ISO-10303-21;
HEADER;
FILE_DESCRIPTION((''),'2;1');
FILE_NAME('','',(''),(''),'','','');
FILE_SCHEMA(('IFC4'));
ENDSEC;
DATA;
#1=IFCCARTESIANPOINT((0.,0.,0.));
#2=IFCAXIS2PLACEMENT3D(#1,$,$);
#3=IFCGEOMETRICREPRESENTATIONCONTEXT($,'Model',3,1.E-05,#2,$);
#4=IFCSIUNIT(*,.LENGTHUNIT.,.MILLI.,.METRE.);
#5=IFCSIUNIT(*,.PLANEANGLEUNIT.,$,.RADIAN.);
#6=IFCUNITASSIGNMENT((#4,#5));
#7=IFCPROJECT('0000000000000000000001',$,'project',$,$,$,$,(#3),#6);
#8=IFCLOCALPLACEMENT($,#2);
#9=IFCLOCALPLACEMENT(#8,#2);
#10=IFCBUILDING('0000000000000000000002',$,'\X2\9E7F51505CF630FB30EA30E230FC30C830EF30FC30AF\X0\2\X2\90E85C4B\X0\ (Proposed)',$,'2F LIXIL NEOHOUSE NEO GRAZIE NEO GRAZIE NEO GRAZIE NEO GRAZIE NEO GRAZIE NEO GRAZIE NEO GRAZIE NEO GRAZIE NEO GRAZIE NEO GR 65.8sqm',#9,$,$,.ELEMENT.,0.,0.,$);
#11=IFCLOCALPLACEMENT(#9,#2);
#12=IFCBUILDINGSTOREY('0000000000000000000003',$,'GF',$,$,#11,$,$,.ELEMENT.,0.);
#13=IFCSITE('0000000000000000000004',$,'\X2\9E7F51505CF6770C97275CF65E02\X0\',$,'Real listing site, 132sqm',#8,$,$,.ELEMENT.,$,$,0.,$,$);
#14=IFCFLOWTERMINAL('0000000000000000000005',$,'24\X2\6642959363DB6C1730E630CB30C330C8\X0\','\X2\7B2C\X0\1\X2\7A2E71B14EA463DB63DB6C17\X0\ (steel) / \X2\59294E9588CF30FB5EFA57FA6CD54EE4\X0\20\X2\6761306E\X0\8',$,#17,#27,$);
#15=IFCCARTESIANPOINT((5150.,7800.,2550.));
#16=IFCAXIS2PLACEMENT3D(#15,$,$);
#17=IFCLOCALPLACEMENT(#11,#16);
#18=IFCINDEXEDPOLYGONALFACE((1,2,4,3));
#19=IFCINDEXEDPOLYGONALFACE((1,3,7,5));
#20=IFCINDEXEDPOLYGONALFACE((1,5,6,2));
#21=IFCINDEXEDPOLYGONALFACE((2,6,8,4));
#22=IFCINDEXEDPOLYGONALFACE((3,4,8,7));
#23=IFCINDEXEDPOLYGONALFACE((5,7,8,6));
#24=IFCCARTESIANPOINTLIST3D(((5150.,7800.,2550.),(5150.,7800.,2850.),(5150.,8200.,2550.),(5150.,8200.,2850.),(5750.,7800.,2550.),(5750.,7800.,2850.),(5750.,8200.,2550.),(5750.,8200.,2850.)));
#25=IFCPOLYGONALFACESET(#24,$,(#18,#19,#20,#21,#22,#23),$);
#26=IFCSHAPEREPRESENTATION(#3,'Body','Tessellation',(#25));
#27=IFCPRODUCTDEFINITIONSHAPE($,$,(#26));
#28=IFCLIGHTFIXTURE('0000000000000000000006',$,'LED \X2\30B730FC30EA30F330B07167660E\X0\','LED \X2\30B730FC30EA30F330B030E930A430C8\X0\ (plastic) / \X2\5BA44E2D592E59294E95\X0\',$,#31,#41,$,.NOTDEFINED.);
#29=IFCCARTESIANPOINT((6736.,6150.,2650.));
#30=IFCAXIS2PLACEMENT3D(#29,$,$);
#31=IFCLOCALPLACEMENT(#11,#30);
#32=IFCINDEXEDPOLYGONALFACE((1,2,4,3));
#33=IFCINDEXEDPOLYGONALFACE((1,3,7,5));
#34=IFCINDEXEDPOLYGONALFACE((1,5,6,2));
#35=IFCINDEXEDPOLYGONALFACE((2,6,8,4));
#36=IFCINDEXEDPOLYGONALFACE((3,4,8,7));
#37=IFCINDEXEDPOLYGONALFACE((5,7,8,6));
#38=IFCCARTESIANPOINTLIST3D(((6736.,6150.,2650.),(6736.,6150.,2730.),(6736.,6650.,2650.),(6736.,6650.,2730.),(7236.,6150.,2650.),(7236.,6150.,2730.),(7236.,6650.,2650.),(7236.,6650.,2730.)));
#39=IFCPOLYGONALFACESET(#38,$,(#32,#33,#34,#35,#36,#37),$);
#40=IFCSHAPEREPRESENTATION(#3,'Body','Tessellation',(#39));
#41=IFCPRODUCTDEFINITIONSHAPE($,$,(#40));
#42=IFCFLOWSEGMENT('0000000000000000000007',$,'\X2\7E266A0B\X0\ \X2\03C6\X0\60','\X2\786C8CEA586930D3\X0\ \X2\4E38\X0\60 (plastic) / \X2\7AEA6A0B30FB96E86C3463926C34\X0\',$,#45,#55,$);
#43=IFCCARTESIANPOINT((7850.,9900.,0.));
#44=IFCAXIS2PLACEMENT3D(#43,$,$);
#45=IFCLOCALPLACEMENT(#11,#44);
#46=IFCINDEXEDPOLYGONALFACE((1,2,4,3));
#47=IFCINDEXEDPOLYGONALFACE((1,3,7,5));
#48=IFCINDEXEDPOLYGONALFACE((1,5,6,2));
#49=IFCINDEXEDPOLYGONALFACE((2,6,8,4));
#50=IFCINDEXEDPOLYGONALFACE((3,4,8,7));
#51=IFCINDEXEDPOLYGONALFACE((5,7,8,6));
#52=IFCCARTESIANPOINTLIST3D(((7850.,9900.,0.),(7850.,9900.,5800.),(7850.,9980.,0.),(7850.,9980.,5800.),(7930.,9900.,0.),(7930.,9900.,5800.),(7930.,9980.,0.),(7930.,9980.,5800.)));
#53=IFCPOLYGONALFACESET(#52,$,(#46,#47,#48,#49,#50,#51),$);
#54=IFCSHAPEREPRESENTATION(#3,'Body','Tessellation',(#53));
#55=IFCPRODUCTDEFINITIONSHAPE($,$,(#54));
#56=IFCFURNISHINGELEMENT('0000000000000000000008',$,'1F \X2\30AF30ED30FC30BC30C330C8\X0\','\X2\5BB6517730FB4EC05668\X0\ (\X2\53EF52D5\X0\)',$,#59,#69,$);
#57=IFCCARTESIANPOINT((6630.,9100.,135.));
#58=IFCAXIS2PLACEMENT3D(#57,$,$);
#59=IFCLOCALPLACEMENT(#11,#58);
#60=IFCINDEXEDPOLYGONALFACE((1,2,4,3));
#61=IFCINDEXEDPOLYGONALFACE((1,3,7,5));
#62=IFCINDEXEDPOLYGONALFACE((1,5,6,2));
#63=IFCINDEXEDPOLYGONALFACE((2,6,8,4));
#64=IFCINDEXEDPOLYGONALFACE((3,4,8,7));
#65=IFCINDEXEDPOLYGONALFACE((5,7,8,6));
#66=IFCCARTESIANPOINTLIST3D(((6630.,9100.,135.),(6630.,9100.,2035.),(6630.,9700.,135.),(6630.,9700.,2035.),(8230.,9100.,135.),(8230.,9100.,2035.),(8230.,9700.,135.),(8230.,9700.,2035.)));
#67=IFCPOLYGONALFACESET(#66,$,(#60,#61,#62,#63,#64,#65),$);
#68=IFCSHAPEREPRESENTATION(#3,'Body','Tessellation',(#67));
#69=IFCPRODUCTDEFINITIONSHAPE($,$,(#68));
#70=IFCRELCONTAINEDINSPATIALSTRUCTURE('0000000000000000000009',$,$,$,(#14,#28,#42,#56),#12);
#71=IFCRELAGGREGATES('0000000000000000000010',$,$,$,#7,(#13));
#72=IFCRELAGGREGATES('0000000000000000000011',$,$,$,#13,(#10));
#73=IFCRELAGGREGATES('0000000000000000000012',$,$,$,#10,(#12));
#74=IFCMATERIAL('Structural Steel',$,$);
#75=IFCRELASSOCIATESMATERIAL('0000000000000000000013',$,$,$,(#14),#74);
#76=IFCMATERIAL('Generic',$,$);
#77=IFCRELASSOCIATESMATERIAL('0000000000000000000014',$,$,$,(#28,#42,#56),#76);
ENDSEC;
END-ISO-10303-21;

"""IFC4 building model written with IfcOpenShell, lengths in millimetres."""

from ifc_helpers import new_model, si_unit, frame, frame_2d, origin, place, context, project, spatial, rectangle, extrude, material, element, save


model = new_model("IFC4")

# Units and contexts
model_context = context("Model", 3, precision=1e-05, world=origin())
ifc_project = project(units=[si_unit("LENGTHUNIT", "METRE", prefix="MILLI"), si_unit("PLANEANGLEUNIT", "RADIAN")], contexts=[model_context])

# Site, building, storey
site_placement = place(None, origin())
site = spatial("IfcSite", under=ifc_project, at=site_placement, Name="鹿児島県霧島市", ObjectType="Real listing site, 132sqm", CompositionType="ELEMENT", RefElevation=0.0)
building_placement = place(site_placement, origin())
building = spatial("IfcBuilding", under=site, at=building_placement, Name="鹿児島・リモートワーク2部屋 (Proposed)", ObjectType="2F LIXIL NEOHOUSE NEO GRAZIE NEO GRAZIE NEO GRAZIE NEO GRAZIE NEO GRAZIE NEO GRAZIE NEO GRAZIE NEO GRAZIE NEO GRAZIE NEO GR 65.8sqm", CompositionType="ELEMENT", ElevationOfRefHeight=0.0, ElevationOfTerrain=0.0)
storey_placement = place(building_placement, origin())
storey = spatial("IfcBuildingStorey", under=building, at=storey_placement, Name="GF", CompositionType="ELEMENT", Elevation=0.0)

# Shared definitions
ifc_material_1 = material(Name="Generic")

# Flow terminal
ifc_material_2 = material(Name="Structural Steel")
flow_terminal_placement = place(storey_placement, frame((5150.0, 7800.0, 2550.0)))
element("IfcFlowTerminal", 1, at=flow_terminal_placement, inside=storey, material=ifc_material_2, Name="24時間換気ユニット", Description="第1種熱交換換気 (steel) / 天井裏・建基法令20条の8", context=model_context, shape_type="SweptSolid", body=[
    extrude(rectangle(XDim=600.0, YDim=400.0, at=frame_2d((300.0, 200.0))), frame((5150.0, 7800.0, 2550.0)), (0.0, 0.0, 1.0), 300.0),
])

# Light fixture
light_fixture_placement = place(storey_placement, frame((6736.0, 6150.0, 2650.0)))
element("IfcLightFixture", 2, at=light_fixture_placement, inside=storey, material=ifc_material_1, Name="LED シーリング照明", Description="LED シーリングライト (plastic) / 室中央天井", PredefinedType="NOTDEFINED", context=model_context, shape_type="SweptSolid", body=[
    extrude(rectangle(XDim=500.0, YDim=500.0, at=frame_2d((250.0, 250.0))), frame((6736.0, 6150.0, 2650.0)), (0.0, 0.0, 1.0), 80.0),
])

# Flow segment
flow_segment_placement = place(storey_placement, frame((7850.0, 9900.0, 0.0)))
element("IfcFlowSegment", 3, at=flow_segment_placement, inside=storey, material=ifc_material_1, Name="縦樋 φ60", Description="硬質塩ビ 丸60 (plastic) / 竪樋・雨水排水", context=model_context, shape_type="SweptSolid", body=[
    extrude(rectangle(XDim=80.0, YDim=80.0, at=frame_2d((40.0, 40.0))), frame((7850.0, 9900.0, 0.0)), (0.0, 0.0, 1.0), 5800.0),
])

# Furnishing element
furnishing_placement = place(storey_placement, frame((6630.0, 9100.0, 135.0)))
element("IfcFurnishingElement", 4, at=furnishing_placement, inside=storey, material=ifc_material_1, Name="1F クローゼット", Description="家具・什器 (可動)", context=model_context, shape_type="SweptSolid", body=[
    extrude(rectangle(XDim=1600.0, YDim=600.0, at=frame_2d((800.0, 300.0))), frame((6630.0, 9100.0, 135.0)), (0.0, 0.0, 1.0), 1900.0),
])

save(model, "model.ifc")
